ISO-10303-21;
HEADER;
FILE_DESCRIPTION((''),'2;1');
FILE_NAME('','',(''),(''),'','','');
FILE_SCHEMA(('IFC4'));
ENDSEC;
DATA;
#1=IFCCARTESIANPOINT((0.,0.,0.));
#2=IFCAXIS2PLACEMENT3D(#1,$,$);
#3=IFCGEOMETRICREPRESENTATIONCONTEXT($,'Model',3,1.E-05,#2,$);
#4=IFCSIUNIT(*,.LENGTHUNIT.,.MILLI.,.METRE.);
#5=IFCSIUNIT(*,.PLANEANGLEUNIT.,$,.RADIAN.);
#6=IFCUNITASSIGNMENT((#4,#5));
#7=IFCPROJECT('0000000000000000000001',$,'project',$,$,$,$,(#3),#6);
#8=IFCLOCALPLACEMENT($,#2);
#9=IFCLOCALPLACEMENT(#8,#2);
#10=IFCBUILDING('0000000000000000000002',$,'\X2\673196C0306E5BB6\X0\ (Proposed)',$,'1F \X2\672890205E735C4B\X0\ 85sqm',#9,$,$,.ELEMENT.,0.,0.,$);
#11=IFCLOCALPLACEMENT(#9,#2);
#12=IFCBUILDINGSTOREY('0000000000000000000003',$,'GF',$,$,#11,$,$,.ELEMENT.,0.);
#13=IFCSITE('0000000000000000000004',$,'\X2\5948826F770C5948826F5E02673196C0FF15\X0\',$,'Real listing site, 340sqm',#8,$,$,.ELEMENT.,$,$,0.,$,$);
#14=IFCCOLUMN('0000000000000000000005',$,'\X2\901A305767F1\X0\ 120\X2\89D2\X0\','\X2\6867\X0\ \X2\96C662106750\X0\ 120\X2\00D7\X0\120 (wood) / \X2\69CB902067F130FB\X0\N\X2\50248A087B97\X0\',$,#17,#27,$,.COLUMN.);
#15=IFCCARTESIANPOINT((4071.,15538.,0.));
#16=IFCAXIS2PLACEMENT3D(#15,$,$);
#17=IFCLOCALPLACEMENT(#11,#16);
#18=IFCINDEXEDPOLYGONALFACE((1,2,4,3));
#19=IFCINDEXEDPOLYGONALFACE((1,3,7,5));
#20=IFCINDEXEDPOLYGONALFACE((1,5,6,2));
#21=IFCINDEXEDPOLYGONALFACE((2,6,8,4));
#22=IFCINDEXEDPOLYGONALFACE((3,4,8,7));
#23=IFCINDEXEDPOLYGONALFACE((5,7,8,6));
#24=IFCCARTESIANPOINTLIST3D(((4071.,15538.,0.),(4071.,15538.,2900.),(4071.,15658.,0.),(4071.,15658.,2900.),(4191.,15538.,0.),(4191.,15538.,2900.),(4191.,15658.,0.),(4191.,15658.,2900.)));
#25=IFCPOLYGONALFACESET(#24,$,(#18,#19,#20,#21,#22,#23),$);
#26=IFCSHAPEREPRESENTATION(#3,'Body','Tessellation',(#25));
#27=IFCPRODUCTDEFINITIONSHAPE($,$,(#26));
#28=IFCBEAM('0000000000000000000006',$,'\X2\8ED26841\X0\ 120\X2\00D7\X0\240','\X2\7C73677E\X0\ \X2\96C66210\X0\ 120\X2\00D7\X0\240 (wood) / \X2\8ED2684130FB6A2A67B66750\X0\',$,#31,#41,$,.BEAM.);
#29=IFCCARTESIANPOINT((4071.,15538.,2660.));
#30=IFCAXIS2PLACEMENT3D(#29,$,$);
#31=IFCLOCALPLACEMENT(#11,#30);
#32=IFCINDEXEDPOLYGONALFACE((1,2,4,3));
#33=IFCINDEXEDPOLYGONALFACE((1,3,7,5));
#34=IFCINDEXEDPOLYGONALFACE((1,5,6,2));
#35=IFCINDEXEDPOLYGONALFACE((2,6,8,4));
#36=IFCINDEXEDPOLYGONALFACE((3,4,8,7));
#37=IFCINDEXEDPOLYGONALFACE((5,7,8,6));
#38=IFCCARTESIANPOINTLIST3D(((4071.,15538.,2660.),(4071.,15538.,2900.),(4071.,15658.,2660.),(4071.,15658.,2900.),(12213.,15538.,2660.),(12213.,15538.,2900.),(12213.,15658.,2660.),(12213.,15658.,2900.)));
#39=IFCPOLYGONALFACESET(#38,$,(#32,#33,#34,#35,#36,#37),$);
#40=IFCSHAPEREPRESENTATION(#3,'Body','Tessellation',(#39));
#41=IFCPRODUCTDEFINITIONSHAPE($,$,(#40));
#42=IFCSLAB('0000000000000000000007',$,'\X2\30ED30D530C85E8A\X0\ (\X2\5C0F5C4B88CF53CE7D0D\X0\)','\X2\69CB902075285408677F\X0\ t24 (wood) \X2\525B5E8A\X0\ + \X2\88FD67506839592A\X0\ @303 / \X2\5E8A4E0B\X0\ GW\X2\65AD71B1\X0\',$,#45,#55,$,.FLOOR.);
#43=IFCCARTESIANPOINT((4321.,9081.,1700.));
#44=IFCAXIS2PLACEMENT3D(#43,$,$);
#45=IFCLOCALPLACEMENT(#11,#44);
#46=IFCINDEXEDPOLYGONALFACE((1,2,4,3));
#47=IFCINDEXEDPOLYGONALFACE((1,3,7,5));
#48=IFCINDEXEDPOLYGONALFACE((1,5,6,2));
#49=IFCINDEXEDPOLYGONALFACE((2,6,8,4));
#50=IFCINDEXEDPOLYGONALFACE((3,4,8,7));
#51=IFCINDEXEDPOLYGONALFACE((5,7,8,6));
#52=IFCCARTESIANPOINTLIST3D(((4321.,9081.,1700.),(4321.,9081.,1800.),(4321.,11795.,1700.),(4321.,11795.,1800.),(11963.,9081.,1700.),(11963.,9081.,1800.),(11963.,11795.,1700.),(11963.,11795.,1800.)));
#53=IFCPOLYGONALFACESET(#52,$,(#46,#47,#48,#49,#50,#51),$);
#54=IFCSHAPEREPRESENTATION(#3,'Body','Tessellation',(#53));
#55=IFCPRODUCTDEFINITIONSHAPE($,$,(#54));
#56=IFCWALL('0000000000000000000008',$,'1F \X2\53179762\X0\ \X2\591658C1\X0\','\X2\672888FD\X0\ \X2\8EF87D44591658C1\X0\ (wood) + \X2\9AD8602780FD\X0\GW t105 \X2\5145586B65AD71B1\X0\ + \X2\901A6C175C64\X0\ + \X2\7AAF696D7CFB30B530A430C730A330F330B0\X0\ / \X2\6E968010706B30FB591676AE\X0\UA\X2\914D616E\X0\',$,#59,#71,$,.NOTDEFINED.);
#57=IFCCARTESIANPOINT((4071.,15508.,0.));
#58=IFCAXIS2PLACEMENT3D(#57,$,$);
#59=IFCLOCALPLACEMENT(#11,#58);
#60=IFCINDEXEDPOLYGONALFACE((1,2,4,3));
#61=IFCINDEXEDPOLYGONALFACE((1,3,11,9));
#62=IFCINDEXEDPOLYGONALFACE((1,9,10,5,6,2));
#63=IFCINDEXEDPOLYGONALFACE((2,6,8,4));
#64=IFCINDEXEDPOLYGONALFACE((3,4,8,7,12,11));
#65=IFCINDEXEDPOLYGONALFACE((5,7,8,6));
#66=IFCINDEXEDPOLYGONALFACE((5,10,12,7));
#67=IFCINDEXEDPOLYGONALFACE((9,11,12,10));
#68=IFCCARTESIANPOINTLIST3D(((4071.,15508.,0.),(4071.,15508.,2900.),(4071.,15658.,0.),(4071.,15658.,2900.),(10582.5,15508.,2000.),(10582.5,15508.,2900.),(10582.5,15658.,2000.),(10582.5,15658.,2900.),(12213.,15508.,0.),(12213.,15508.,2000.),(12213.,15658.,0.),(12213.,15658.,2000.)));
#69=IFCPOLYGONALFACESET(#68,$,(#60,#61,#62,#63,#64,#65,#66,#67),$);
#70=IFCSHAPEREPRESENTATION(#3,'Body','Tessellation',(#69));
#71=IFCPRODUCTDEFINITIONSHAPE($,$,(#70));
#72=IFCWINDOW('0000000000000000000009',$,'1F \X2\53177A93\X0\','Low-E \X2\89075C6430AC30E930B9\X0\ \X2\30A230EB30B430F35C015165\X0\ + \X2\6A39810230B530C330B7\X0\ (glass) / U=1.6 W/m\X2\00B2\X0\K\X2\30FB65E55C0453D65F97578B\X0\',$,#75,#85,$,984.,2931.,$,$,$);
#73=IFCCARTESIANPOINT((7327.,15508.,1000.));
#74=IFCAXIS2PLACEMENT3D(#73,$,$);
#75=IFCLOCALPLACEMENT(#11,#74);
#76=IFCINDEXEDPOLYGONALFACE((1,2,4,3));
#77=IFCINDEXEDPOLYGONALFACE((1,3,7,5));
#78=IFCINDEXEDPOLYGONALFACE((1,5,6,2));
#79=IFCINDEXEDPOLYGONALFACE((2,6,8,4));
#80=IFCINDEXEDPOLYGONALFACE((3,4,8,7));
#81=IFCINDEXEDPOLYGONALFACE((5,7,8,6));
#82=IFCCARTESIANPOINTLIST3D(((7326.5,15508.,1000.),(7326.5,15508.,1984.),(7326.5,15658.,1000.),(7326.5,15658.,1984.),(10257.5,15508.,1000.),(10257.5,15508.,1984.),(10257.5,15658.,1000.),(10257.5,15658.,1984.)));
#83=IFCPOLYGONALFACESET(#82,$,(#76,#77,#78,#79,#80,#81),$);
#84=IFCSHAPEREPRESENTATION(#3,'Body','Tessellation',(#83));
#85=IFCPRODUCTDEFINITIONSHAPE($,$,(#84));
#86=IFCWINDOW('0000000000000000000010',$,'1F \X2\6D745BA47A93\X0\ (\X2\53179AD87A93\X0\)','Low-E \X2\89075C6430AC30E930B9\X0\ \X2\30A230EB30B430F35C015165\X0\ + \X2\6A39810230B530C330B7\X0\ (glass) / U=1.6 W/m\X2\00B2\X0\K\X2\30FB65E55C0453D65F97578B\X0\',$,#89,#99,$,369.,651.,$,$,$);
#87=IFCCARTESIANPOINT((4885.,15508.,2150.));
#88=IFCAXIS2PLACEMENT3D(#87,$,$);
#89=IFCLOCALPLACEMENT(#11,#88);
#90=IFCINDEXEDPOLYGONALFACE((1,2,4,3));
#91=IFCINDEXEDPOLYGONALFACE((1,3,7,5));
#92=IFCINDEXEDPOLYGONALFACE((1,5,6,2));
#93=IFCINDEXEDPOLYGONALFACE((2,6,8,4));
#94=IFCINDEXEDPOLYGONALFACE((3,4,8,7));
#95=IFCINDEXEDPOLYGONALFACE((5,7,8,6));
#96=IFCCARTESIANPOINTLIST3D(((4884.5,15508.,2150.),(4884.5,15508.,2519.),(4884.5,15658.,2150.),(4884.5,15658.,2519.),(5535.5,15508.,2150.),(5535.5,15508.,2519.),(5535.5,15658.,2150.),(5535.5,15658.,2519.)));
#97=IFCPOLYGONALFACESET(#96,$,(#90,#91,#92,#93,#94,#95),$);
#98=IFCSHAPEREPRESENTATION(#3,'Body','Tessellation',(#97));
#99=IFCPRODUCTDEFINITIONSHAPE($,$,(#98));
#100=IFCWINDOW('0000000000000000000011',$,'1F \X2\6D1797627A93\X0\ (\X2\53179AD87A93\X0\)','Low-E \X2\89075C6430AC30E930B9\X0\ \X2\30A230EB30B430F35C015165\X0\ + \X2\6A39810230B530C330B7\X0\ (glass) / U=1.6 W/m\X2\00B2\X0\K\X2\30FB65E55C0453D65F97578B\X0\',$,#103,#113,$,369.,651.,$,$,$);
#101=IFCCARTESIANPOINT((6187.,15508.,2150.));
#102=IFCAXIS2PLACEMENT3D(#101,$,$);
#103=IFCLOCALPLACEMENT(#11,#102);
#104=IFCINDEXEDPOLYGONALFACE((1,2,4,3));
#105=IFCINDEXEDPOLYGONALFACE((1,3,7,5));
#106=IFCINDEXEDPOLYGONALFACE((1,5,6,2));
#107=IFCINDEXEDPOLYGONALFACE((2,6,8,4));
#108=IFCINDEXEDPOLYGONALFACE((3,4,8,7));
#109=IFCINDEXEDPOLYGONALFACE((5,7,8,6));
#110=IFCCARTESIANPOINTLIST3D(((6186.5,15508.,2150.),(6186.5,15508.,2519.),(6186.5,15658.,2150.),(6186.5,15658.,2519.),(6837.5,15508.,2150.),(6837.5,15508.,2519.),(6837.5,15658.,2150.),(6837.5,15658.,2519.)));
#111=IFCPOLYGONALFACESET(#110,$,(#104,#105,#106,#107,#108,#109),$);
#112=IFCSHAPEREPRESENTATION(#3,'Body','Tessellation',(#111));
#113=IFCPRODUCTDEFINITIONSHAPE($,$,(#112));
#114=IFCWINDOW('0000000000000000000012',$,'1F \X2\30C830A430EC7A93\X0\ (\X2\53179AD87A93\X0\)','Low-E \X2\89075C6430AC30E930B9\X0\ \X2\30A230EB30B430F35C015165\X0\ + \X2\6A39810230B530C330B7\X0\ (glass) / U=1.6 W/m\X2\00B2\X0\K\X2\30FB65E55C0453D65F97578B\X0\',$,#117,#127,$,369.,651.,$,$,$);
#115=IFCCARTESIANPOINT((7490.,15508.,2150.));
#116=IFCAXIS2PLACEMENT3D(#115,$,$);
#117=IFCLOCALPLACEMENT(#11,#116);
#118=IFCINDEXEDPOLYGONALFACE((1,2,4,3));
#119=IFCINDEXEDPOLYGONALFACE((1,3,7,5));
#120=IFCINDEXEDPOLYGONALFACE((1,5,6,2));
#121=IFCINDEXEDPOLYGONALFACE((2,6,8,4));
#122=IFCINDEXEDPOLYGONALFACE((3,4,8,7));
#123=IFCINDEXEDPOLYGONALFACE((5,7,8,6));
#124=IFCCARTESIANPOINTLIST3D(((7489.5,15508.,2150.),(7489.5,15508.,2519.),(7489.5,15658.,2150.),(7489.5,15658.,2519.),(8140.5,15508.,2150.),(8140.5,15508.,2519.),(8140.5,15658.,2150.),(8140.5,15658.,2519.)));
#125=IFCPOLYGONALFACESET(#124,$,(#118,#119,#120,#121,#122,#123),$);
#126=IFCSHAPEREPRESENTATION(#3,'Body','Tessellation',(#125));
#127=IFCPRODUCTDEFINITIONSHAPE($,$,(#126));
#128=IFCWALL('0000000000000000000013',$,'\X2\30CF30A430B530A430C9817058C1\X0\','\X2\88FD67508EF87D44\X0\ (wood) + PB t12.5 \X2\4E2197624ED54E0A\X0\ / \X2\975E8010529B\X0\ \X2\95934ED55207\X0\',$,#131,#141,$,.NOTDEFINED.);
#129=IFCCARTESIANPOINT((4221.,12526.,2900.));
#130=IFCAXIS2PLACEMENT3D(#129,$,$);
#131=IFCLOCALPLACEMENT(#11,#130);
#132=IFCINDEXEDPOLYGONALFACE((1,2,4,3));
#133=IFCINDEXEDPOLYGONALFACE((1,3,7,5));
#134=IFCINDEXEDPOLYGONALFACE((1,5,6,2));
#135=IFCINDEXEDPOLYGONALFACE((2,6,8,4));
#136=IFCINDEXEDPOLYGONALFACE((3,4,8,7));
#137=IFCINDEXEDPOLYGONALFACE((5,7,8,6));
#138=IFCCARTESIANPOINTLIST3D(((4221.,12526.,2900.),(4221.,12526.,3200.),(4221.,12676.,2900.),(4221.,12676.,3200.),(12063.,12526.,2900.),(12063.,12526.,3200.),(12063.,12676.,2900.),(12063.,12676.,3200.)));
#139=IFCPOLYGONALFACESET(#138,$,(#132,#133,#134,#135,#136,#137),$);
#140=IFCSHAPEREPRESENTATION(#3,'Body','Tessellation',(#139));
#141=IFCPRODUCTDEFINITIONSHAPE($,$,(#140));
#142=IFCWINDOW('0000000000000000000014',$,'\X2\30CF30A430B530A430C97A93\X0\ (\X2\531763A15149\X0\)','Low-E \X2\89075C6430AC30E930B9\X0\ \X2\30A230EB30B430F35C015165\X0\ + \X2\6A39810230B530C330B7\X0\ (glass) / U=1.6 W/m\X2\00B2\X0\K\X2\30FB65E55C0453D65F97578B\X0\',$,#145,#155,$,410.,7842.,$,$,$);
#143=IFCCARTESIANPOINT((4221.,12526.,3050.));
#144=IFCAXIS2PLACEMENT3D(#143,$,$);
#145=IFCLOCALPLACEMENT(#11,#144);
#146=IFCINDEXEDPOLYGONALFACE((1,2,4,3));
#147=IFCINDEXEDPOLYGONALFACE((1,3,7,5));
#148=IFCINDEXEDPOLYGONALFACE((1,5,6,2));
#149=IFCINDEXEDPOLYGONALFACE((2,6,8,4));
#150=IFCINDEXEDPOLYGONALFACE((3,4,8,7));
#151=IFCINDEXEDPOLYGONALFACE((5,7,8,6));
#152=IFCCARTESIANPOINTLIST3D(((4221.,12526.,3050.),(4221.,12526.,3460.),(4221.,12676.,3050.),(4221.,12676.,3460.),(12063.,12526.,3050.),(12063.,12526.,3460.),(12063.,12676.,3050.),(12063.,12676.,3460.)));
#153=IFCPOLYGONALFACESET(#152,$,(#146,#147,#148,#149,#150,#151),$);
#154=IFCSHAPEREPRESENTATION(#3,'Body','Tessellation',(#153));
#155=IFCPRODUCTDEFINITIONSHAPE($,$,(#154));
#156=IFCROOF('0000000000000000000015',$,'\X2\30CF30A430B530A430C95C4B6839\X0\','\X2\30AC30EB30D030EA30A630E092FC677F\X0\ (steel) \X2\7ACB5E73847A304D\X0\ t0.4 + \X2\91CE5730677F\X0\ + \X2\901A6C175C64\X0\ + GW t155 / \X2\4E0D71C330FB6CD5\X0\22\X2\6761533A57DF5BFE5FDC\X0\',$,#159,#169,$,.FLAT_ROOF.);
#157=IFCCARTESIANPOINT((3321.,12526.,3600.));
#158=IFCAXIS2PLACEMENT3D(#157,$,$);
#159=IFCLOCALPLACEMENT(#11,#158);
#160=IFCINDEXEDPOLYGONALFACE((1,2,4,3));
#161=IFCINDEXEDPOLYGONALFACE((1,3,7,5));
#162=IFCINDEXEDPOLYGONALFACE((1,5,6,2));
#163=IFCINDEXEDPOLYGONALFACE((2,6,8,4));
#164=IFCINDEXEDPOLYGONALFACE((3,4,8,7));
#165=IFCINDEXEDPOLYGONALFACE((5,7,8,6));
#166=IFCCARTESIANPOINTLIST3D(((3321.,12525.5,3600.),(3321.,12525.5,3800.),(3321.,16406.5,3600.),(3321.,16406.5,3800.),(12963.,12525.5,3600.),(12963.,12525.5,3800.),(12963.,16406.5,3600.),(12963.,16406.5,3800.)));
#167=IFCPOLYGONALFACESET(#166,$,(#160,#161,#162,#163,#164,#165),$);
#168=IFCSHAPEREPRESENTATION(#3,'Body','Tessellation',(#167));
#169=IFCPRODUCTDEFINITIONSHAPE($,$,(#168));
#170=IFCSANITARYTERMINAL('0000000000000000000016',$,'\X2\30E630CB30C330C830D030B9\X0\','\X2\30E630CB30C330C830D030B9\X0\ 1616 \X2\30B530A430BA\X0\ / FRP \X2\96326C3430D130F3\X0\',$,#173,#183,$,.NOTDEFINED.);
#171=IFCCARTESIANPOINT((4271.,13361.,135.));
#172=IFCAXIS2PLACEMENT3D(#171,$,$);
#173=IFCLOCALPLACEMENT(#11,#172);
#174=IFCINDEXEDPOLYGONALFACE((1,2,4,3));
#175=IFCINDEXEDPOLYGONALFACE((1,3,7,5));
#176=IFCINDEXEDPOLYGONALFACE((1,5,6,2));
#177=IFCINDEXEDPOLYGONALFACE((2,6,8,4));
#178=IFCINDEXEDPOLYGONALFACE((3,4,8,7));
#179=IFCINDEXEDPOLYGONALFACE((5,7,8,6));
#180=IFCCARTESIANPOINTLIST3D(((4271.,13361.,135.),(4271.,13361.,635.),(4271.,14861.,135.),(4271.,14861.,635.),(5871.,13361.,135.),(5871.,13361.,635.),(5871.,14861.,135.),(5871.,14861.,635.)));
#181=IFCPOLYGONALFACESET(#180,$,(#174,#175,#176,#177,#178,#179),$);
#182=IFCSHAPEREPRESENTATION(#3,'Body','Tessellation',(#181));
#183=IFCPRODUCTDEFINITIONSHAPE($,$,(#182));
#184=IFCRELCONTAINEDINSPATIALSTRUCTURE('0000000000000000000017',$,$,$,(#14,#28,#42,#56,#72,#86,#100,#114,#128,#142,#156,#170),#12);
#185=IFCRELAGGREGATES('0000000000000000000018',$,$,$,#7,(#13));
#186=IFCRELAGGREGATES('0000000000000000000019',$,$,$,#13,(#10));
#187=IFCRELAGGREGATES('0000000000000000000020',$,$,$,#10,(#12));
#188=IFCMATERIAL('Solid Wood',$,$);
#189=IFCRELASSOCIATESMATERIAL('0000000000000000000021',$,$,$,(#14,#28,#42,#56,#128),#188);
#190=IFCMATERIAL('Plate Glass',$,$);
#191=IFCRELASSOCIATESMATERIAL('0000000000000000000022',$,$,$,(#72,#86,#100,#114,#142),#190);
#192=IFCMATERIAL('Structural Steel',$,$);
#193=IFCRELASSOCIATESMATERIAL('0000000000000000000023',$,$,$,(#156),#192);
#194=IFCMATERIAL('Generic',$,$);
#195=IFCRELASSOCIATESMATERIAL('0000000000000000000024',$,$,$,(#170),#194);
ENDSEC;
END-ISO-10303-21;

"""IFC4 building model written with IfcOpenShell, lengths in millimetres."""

from ifc_helpers import new_model, si_unit, frame, frame_2d, origin, place, context, project, spatial, rectangle, extrude, material, element, fill, save


model = new_model("IFC4")

# Units and contexts
model_context = context("Model", 3, precision=1e-05, world=origin())
ifc_project = project(units=[si_unit("LENGTHUNIT", "METRE", prefix="MILLI"), si_unit("PLANEANGLEUNIT", "RADIAN")], contexts=[model_context])

# Site, building, storey
site_placement = place(None, origin())
site = spatial("IfcSite", under=ifc_project, at=site_placement, Name="奈良県奈良市朱雀５", ObjectType="Real listing site, 340sqm", CompositionType="ELEMENT", RefElevation=0.0)
building_placement = place(site_placement, origin())
building = spatial("IfcBuilding", under=site, at=building_placement, Name="朱雀の家 (Proposed)", ObjectType="1F 木造平屋 85sqm", CompositionType="ELEMENT", ElevationOfRefHeight=0.0, ElevationOfTerrain=0.0)
storey_placement = place(building_placement, origin())
storey = spatial("IfcBuildingStorey", under=building, at=storey_placement, Name="GF", CompositionType="ELEMENT", Elevation=0.0)

# Column
ifc_material_1 = material(Name="Solid Wood")
column_1_placement = place(storey_placement, frame((4071.0, 15538.0, 0.0)))
element("IfcColumn", 1, at=column_1_placement, inside=storey, material=ifc_material_1, Name="通し柱 120角", Description="桧 集成材 120×120 (wood) / 構造柱・N値計算", PredefinedType="COLUMN", context=model_context, shape_type="SweptSolid", body=[
    extrude(rectangle(XDim=120.0, YDim=120.0, at=frame_2d((60.0, 60.0))), frame((4071.0, 15538.0, 0.0)), (0.0, 0.0, 1.0), 2900.0),
])

# Beam
beam_1_placement = place(storey_placement, frame((4071.0, 15538.0, 2660.0)))
element("IfcBeam", 2, at=beam_1_placement, inside=storey, material=ifc_material_1, Name="軒桁 120×240", Description="米松 集成 120×240 (wood) / 軒桁・横架材", PredefinedType="BEAM", context=model_context, shape_type="SweptSolid", body=[
    extrude(rectangle(XDim=8142.0, YDim=120.0, at=frame_2d((4071.0, 60.0))), frame((4071.0, 15538.0, 2660.0)), (0.0, 0.0, 1.0), 240.0),
])

# Slab
slab_placement = place(storey_placement, frame((4321.0, 9081.0, 1700.0)))
element("IfcSlab", 3, at=slab_placement, inside=storey, material=ifc_material_1, Name="ロフト床 (小屋裏収納)", Description="構造用合板 t24 (wood) 剛床 + 製材根太 @303 / 床下 GW断熱", PredefinedType="FLOOR", context=model_context, shape_type="SweptSolid", body=[
    extrude(rectangle(XDim=7642.0, YDim=2714.0, at=frame_2d((3821.0, 1357.0))), frame((4321.0, 9081.0, 1700.0)), (0.0, 0.0, 1.0), 100.0),
])

# Wall, openings, windows
wall_1_placement = place(storey_placement, frame((4071.0, 15508.0, 0.0)))
wall_1 = element("IfcWall", 4, at=wall_1_placement, inside=storey, material=ifc_material_1, Name="1F 北面 外壁", Description="木製 軸組外壁 (wood) + 高性能GW t105 充填断熱 + 通気層 + 窯業系サイディング / 準耐火・外皮UA配慮", PredefinedType="NOTDEFINED", context=model_context, shape_type="SweptSolid", body=[
    extrude(rectangle(XDim=8142.0, YDim=150.0, at=frame_2d((4071.0, 75.0))), frame((4071.0, 15508.0, 0.0)), (0.0, 0.0, 1.0), 2900.0),
])
opening_1_placement = place(storey_placement, frame((7327.0, 15508.0, 1000.0)))
opening_1 = element("IfcOpeningElement", 5, at=opening_1_placement, cuts=wall_1, PredefinedType="NOTDEFINED", context=model_context, shape_type="SweptSolid", body=[
    extrude(rectangle(XDim=2931.0, YDim=150.0, at=frame_2d((1465.0, 75.0))), frame((7327.0, 15508.0, 1000.0)), (0.0, 0.0, 1.0), 984.0),
])
opening_2_placement = place(storey_placement, frame((4885.0, 15508.0, 2150.0)))
opening_2 = element("IfcOpeningElement", 6, at=opening_2_placement, cuts=wall_1, PredefinedType="NOTDEFINED", context=model_context, shape_type="SweptSolid", body=[
    extrude(rectangle(XDim=651.0, YDim=150.0, at=frame_2d((325.0, 75.0))), frame((4885.0, 15508.0, 2150.0)), (0.0, 0.0, 1.0), 369.0),
])
opening_3_placement = place(storey_placement, frame((6187.0, 15508.0, 2150.0)))
opening_3 = element("IfcOpeningElement", 7, at=opening_3_placement, cuts=wall_1, PredefinedType="NOTDEFINED", context=model_context, shape_type="SweptSolid", body=[
    extrude(rectangle(XDim=651.0, YDim=150.0, at=frame_2d((325.0, 75.0))), frame((6187.0, 15508.0, 2150.0)), (0.0, 0.0, 1.0), 369.0),
])
opening_4_placement = place(storey_placement, frame((7490.0, 15508.0, 2150.0)))
opening_4 = element("IfcOpeningElement", 8, at=opening_4_placement, cuts=wall_1, PredefinedType="NOTDEFINED", context=model_context, shape_type="SweptSolid", body=[
    extrude(rectangle(XDim=651.0, YDim=150.0, at=frame_2d((325.0, 75.0))), frame((7490.0, 15508.0, 2150.0)), (0.0, 0.0, 1.0), 369.0),
])
ifc_material_2 = material(Name="Plate Glass")
window_1_placement = place(storey_placement, frame((7327.0, 15508.0, 1000.0)))
window_1 = element("IfcWindow", 9, at=window_1_placement, inside=storey, material=ifc_material_2, Name="1F 北窓", Description="Low-E 複層ガラス アルゴン封入 + 樹脂サッシ (glass) / U=1.6 W/m²K・日射取得型", OverallHeight=984.0, OverallWidth=2931.0, context=model_context, shape_type="SweptSolid", body=[
    extrude(rectangle(XDim=2931.0, YDim=150.0, at=frame_2d((1465.0, 75.0))), frame((7327.0, 15508.0, 1000.0)), (0.0, 0.0, 1.0), 984.0),
])
fill(opening_1, window_1)
window_2_placement = place(storey_placement, frame((4885.0, 15508.0, 2150.0)))
window_2 = element("IfcWindow", 10, at=window_2_placement, inside=storey, material=ifc_material_2, Name="1F 浴室窓 (北高窓)", Description="Low-E 複層ガラス アルゴン封入 + 樹脂サッシ (glass) / U=1.6 W/m²K・日射取得型", OverallHeight=369.0, OverallWidth=651.0, context=model_context, shape_type="SweptSolid", body=[
    extrude(rectangle(XDim=651.0, YDim=150.0, at=frame_2d((325.0, 75.0))), frame((4885.0, 15508.0, 2150.0)), (0.0, 0.0, 1.0), 369.0),
])
fill(opening_2, window_2)
window_3_placement = place(storey_placement, frame((6187.0, 15508.0, 2150.0)))
window_3 = element("IfcWindow", 11, at=window_3_placement, inside=storey, material=ifc_material_2, Name="1F 洗面窓 (北高窓)", Description="Low-E 複層ガラス アルゴン封入 + 樹脂サッシ (glass) / U=1.6 W/m²K・日射取得型", OverallHeight=369.0, OverallWidth=651.0, context=model_context, shape_type="SweptSolid", body=[
    extrude(rectangle(XDim=651.0, YDim=150.0, at=frame_2d((325.0, 75.0))), frame((6187.0, 15508.0, 2150.0)), (0.0, 0.0, 1.0), 369.0),
])
fill(opening_3, window_3)
window_4_placement = place(storey_placement, frame((7490.0, 15508.0, 2150.0)))
window_4 = element("IfcWindow", 12, at=window_4_placement, inside=storey, material=ifc_material_2, Name="1F トイレ窓 (北高窓)", Description="Low-E 複層ガラス アルゴン封入 + 樹脂サッシ (glass) / U=1.6 W/m²K・日射取得型", OverallHeight=369.0, OverallWidth=651.0, context=model_context, shape_type="SweptSolid", body=[
    extrude(rectangle(XDim=651.0, YDim=150.0, at=frame_2d((325.0, 75.0))), frame((7490.0, 15508.0, 2150.0)), (0.0, 0.0, 1.0), 369.0),
])
fill(opening_4, window_4)

# Wall, opening, window
wall_2_placement = place(storey_placement, frame((4221.0, 12526.0, 2900.0)))
wall_2 = element("IfcWall", 13, at=wall_2_placement, inside=storey, material=ifc_material_1, Name="ハイサイド腰壁", Description="製材軸組 (wood) + PB t12.5 両面仕上 / 非耐力 間仕切", PredefinedType="NOTDEFINED", context=model_context, shape_type="SweptSolid", body=[
    extrude(rectangle(XDim=7842.0, YDim=150.0, at=frame_2d((3921.0, 75.0))), frame((4221.0, 12526.0, 2900.0)), (0.0, 0.0, 1.0), 700.0),
])
opening_5_placement = place(storey_placement, frame((4221.0, 12526.0, 3050.0)))
opening_5 = element("IfcOpeningElement", 14, at=opening_5_placement, cuts=wall_2, PredefinedType="NOTDEFINED", context=model_context, shape_type="SweptSolid", body=[
    extrude(rectangle(XDim=7842.0, YDim=150.0, at=frame_2d((3921.0, 75.0))), frame((4221.0, 12526.0, 3050.0)), (0.0, 0.0, 1.0), 410.0),
])
window_5_placement = place(storey_placement, frame((4221.0, 12526.0, 3050.0)))
window_5 = element("IfcWindow", 15, at=window_5_placement, inside=storey, material=ifc_material_2, Name="ハイサイド窓 (北採光)", Description="Low-E 複層ガラス アルゴン封入 + 樹脂サッシ (glass) / U=1.6 W/m²K・日射取得型", OverallHeight=410.0, OverallWidth=7842.0, context=model_context, shape_type="SweptSolid", body=[
    extrude(rectangle(XDim=7842.0, YDim=150.0, at=frame_2d((3921.0, 75.0))), frame((4221.0, 12526.0, 3050.0)), (0.0, 0.0, 1.0), 410.0),
])
fill(opening_5, window_5)

# Roof
ifc_material_3 = material(Name="Structural Steel")
roof_placement = place(storey_placement, frame((3321.0, 12526.0, 3600.0)))
element("IfcRoof", 16, at=roof_placement, inside=storey, material=ifc_material_3, Name="ハイサイド屋根", Description="ガルバリウム鋼板 (steel) 立平葺き t0.4 + 野地板 + 通気層 + GW t155 / 不燃・法22条区域対応", PredefinedType="FLAT_ROOF", context=model_context, shape_type="SweptSolid", body=[
    extrude(rectangle(XDim=9642.0, YDim=3881.0, at=frame_2d((4821.0, 1940.0))), frame((3321.0, 12526.0, 3600.0)), (0.0, 0.0, 1.0), 200.0),
])

# Sanitary terminal
ifc_material_4 = material(Name="Generic")
sanitary_terminal_placement = place(storey_placement, frame((4271.0, 13361.0, 135.0)))
element("IfcSanitaryTerminal", 17, at=sanitary_terminal_placement, inside=storey, material=ifc_material_4, Name="ユニットバス", Description="ユニットバス 1616 サイズ / FRP 防水パン", PredefinedType="NOTDEFINED", context=model_context, shape_type="SweptSolid", body=[
    extrude(rectangle(XDim=1600.0, YDim=1500.0, at=frame_2d((800.0, 750.0))), frame((4271.0, 13361.0, 135.0)), (0.0, 0.0, 1.0), 500.0),
])

save(model, "model.ifc")
